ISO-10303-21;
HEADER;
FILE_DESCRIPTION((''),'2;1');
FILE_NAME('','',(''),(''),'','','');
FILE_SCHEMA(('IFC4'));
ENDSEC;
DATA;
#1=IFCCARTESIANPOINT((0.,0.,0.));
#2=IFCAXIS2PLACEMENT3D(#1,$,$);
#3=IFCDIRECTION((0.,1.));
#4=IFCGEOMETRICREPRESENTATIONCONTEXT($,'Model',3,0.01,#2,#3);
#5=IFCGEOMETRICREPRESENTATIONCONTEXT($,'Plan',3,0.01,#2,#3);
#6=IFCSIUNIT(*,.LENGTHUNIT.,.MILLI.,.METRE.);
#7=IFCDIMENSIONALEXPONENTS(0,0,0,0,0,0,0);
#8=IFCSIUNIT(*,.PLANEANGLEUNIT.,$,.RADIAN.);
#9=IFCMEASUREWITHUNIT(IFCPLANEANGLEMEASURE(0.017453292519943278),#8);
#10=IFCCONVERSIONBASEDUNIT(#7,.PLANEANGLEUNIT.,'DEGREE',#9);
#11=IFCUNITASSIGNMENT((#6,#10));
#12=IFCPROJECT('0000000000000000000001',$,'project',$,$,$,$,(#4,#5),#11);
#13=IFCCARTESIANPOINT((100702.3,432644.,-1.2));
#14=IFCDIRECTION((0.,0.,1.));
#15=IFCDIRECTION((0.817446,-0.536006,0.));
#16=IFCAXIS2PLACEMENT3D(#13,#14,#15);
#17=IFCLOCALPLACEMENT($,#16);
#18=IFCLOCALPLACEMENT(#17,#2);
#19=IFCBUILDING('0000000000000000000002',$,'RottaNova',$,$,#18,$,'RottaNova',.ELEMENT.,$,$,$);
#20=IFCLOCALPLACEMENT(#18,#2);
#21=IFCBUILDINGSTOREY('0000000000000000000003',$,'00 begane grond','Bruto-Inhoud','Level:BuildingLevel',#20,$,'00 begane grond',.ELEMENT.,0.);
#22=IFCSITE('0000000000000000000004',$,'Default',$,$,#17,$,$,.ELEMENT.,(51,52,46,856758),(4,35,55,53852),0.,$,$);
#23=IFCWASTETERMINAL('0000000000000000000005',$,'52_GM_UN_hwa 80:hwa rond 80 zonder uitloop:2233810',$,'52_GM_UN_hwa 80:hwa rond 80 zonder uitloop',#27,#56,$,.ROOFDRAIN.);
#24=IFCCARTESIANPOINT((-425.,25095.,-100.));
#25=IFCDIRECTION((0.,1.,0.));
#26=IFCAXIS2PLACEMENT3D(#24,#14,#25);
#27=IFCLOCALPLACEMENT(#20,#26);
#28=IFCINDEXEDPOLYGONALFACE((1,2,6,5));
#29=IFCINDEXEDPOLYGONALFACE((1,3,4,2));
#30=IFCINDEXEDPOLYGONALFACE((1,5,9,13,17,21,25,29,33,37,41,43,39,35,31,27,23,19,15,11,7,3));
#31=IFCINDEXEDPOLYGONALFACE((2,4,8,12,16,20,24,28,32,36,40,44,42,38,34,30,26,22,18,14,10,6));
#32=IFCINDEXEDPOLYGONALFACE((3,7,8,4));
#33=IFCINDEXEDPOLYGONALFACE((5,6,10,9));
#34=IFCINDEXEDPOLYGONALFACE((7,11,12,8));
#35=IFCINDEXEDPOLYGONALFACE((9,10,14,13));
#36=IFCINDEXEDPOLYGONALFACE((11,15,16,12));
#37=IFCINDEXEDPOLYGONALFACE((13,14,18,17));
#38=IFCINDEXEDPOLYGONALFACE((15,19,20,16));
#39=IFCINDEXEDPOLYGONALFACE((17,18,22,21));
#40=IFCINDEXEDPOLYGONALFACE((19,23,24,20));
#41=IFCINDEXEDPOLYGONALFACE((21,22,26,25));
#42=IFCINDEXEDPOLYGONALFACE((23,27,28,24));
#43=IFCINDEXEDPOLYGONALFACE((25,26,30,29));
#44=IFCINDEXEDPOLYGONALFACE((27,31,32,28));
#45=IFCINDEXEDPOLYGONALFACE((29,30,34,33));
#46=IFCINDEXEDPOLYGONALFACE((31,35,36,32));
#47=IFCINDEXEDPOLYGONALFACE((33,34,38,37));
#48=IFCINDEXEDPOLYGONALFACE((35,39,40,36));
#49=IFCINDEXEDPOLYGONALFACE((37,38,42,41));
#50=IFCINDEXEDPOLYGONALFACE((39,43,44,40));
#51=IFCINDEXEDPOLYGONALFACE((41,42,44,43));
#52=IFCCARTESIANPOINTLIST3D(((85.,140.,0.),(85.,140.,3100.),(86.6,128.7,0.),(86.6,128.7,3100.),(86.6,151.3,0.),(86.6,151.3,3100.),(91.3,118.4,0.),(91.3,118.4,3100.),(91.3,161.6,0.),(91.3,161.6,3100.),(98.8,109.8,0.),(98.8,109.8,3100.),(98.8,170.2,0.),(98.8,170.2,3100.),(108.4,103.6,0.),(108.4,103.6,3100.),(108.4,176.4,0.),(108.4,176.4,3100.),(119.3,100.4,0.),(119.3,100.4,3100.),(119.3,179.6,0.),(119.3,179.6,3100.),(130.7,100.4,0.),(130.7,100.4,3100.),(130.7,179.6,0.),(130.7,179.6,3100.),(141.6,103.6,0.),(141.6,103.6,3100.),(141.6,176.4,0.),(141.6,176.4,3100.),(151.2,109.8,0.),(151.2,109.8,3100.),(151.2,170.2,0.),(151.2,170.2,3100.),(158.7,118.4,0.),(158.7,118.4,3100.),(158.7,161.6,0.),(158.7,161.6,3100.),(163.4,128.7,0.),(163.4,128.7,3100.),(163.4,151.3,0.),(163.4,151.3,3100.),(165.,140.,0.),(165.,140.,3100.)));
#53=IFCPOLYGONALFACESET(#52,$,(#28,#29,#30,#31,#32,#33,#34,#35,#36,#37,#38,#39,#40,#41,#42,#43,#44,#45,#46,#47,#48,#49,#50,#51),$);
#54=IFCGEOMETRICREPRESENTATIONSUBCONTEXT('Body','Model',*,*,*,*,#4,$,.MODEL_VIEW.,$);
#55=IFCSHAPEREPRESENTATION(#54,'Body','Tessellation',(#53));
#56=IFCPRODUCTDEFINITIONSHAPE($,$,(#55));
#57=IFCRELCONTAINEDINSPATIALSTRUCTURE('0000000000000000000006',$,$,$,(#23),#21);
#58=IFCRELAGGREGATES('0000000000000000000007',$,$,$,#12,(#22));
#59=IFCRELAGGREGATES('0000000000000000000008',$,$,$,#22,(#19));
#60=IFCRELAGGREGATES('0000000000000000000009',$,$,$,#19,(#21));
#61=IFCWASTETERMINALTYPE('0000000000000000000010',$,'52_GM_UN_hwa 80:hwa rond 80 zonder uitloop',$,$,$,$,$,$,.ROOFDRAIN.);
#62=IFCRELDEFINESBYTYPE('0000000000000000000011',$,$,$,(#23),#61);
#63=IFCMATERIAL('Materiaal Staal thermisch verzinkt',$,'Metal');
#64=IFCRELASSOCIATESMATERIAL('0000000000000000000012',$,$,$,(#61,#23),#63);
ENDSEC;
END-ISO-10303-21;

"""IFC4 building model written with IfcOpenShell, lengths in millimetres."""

from ifc_helpers import new_model, entity, si_unit, converted_unit, direction, frame, origin, place, context, subcontext, project, spatial, arc, indexed_curve, outline, extrude, source, transform, mapped, material, type_object, type_shapes, element, save


model = new_model("IFC4")

# Units and contexts
model_context = context("Model", 3, precision=0.01, world=origin(), true_north=direction((0.0, 1.0)))
plan_context = context("Plan", 3, precision=0.01, world=origin(), true_north=direction((0.0, 1.0)))
body_context = subcontext(model_context, "Body", "Model", "MODEL_VIEW")
ifc_project = project(units=[si_unit("LENGTHUNIT", "METRE", prefix="MILLI"), converted_unit("PLANEANGLEUNIT", "DEGREE", entity("IfcPlaneAngleMeasure", 0.017453292519943278), si_unit("PLANEANGLEUNIT", "RADIAN"), dimensions=[0, 0, 0, 0, 0, 0, 0])], contexts=[model_context, plan_context])

# Site, building, storey
site_placement = place(None, frame((100702.3, 432644.0, -1.2), z_axis=(0.0, 0.0, 1.0), x_axis=(0.817446, -0.536006, 0.0)))
site = spatial("IfcSite", under=ifc_project, at=site_placement, Name="Default", CompositionType="ELEMENT", RefLatitude=(51, 52, 46, 856758), RefLongitude=(4, 35, 55, 53852), RefElevation=0.0)
building_placement = place(site_placement, origin())
building = spatial("IfcBuilding", under=site, at=building_placement, Name="RottaNova", LongName="RottaNova", CompositionType="ELEMENT")
storey_placement = place(building_placement, origin())
storey = spatial("IfcBuildingStorey", under=building, at=storey_placement, Name="00 begane grond", Description="Bruto-Inhoud", ObjectType="Level:BuildingLevel", LongName="00 begane grond", CompositionType="ELEMENT", Elevation=0.0)

# Waste terminal
ifc_material_1 = material(Name="Materiaal Staal thermisch verzinkt", Category="Metal")
waste_terminal_type = type_object("IfcWasteTerminalType", Name="52_GM_UN_hwa 80:hwa rond 80 zonder uitloop", PredefinedType="ROOFDRAIN", material=ifc_material_1)
shared_shape = source(origin(), body_context, "Body", "SweptSolid", [
    extrude(outline(indexed_curve([(-40.0, 0.0), (0.0, -40.0), (40.0, 0.0), (0.0, 40.0)], segments=[arc(1, 2, 3), arc(3, 4, 1)], self_intersect=False)), frame((125.0, 140.0, 0.0)), (0.0, 0.0, 1.0), 3100.0),
])
type_shapes(waste_terminal_type, [shared_shape])
waste_terminal_placement = place(storey_placement, frame((-425.0, 25095.0, -100.0), z_axis=(0.0, 0.0, 1.0), x_axis=(0.0, 1.0, 0.0)))
element("IfcWasteTerminal", 1, at=waste_terminal_placement, inside=storey, type_object=waste_terminal_type, material=ifc_material_1, Name="52_GM_UN_hwa 80:hwa rond 80 zonder uitloop:2233810", ObjectType="52_GM_UN_hwa 80:hwa rond 80 zonder uitloop", PredefinedType="ROOFDRAIN", context=body_context, shape_type="MappedRepresentation", body=[
    mapped(shared_shape, transform((0.0, 0.0, 0.0), scale=1.0)),
])

save(model, "model.ifc")
